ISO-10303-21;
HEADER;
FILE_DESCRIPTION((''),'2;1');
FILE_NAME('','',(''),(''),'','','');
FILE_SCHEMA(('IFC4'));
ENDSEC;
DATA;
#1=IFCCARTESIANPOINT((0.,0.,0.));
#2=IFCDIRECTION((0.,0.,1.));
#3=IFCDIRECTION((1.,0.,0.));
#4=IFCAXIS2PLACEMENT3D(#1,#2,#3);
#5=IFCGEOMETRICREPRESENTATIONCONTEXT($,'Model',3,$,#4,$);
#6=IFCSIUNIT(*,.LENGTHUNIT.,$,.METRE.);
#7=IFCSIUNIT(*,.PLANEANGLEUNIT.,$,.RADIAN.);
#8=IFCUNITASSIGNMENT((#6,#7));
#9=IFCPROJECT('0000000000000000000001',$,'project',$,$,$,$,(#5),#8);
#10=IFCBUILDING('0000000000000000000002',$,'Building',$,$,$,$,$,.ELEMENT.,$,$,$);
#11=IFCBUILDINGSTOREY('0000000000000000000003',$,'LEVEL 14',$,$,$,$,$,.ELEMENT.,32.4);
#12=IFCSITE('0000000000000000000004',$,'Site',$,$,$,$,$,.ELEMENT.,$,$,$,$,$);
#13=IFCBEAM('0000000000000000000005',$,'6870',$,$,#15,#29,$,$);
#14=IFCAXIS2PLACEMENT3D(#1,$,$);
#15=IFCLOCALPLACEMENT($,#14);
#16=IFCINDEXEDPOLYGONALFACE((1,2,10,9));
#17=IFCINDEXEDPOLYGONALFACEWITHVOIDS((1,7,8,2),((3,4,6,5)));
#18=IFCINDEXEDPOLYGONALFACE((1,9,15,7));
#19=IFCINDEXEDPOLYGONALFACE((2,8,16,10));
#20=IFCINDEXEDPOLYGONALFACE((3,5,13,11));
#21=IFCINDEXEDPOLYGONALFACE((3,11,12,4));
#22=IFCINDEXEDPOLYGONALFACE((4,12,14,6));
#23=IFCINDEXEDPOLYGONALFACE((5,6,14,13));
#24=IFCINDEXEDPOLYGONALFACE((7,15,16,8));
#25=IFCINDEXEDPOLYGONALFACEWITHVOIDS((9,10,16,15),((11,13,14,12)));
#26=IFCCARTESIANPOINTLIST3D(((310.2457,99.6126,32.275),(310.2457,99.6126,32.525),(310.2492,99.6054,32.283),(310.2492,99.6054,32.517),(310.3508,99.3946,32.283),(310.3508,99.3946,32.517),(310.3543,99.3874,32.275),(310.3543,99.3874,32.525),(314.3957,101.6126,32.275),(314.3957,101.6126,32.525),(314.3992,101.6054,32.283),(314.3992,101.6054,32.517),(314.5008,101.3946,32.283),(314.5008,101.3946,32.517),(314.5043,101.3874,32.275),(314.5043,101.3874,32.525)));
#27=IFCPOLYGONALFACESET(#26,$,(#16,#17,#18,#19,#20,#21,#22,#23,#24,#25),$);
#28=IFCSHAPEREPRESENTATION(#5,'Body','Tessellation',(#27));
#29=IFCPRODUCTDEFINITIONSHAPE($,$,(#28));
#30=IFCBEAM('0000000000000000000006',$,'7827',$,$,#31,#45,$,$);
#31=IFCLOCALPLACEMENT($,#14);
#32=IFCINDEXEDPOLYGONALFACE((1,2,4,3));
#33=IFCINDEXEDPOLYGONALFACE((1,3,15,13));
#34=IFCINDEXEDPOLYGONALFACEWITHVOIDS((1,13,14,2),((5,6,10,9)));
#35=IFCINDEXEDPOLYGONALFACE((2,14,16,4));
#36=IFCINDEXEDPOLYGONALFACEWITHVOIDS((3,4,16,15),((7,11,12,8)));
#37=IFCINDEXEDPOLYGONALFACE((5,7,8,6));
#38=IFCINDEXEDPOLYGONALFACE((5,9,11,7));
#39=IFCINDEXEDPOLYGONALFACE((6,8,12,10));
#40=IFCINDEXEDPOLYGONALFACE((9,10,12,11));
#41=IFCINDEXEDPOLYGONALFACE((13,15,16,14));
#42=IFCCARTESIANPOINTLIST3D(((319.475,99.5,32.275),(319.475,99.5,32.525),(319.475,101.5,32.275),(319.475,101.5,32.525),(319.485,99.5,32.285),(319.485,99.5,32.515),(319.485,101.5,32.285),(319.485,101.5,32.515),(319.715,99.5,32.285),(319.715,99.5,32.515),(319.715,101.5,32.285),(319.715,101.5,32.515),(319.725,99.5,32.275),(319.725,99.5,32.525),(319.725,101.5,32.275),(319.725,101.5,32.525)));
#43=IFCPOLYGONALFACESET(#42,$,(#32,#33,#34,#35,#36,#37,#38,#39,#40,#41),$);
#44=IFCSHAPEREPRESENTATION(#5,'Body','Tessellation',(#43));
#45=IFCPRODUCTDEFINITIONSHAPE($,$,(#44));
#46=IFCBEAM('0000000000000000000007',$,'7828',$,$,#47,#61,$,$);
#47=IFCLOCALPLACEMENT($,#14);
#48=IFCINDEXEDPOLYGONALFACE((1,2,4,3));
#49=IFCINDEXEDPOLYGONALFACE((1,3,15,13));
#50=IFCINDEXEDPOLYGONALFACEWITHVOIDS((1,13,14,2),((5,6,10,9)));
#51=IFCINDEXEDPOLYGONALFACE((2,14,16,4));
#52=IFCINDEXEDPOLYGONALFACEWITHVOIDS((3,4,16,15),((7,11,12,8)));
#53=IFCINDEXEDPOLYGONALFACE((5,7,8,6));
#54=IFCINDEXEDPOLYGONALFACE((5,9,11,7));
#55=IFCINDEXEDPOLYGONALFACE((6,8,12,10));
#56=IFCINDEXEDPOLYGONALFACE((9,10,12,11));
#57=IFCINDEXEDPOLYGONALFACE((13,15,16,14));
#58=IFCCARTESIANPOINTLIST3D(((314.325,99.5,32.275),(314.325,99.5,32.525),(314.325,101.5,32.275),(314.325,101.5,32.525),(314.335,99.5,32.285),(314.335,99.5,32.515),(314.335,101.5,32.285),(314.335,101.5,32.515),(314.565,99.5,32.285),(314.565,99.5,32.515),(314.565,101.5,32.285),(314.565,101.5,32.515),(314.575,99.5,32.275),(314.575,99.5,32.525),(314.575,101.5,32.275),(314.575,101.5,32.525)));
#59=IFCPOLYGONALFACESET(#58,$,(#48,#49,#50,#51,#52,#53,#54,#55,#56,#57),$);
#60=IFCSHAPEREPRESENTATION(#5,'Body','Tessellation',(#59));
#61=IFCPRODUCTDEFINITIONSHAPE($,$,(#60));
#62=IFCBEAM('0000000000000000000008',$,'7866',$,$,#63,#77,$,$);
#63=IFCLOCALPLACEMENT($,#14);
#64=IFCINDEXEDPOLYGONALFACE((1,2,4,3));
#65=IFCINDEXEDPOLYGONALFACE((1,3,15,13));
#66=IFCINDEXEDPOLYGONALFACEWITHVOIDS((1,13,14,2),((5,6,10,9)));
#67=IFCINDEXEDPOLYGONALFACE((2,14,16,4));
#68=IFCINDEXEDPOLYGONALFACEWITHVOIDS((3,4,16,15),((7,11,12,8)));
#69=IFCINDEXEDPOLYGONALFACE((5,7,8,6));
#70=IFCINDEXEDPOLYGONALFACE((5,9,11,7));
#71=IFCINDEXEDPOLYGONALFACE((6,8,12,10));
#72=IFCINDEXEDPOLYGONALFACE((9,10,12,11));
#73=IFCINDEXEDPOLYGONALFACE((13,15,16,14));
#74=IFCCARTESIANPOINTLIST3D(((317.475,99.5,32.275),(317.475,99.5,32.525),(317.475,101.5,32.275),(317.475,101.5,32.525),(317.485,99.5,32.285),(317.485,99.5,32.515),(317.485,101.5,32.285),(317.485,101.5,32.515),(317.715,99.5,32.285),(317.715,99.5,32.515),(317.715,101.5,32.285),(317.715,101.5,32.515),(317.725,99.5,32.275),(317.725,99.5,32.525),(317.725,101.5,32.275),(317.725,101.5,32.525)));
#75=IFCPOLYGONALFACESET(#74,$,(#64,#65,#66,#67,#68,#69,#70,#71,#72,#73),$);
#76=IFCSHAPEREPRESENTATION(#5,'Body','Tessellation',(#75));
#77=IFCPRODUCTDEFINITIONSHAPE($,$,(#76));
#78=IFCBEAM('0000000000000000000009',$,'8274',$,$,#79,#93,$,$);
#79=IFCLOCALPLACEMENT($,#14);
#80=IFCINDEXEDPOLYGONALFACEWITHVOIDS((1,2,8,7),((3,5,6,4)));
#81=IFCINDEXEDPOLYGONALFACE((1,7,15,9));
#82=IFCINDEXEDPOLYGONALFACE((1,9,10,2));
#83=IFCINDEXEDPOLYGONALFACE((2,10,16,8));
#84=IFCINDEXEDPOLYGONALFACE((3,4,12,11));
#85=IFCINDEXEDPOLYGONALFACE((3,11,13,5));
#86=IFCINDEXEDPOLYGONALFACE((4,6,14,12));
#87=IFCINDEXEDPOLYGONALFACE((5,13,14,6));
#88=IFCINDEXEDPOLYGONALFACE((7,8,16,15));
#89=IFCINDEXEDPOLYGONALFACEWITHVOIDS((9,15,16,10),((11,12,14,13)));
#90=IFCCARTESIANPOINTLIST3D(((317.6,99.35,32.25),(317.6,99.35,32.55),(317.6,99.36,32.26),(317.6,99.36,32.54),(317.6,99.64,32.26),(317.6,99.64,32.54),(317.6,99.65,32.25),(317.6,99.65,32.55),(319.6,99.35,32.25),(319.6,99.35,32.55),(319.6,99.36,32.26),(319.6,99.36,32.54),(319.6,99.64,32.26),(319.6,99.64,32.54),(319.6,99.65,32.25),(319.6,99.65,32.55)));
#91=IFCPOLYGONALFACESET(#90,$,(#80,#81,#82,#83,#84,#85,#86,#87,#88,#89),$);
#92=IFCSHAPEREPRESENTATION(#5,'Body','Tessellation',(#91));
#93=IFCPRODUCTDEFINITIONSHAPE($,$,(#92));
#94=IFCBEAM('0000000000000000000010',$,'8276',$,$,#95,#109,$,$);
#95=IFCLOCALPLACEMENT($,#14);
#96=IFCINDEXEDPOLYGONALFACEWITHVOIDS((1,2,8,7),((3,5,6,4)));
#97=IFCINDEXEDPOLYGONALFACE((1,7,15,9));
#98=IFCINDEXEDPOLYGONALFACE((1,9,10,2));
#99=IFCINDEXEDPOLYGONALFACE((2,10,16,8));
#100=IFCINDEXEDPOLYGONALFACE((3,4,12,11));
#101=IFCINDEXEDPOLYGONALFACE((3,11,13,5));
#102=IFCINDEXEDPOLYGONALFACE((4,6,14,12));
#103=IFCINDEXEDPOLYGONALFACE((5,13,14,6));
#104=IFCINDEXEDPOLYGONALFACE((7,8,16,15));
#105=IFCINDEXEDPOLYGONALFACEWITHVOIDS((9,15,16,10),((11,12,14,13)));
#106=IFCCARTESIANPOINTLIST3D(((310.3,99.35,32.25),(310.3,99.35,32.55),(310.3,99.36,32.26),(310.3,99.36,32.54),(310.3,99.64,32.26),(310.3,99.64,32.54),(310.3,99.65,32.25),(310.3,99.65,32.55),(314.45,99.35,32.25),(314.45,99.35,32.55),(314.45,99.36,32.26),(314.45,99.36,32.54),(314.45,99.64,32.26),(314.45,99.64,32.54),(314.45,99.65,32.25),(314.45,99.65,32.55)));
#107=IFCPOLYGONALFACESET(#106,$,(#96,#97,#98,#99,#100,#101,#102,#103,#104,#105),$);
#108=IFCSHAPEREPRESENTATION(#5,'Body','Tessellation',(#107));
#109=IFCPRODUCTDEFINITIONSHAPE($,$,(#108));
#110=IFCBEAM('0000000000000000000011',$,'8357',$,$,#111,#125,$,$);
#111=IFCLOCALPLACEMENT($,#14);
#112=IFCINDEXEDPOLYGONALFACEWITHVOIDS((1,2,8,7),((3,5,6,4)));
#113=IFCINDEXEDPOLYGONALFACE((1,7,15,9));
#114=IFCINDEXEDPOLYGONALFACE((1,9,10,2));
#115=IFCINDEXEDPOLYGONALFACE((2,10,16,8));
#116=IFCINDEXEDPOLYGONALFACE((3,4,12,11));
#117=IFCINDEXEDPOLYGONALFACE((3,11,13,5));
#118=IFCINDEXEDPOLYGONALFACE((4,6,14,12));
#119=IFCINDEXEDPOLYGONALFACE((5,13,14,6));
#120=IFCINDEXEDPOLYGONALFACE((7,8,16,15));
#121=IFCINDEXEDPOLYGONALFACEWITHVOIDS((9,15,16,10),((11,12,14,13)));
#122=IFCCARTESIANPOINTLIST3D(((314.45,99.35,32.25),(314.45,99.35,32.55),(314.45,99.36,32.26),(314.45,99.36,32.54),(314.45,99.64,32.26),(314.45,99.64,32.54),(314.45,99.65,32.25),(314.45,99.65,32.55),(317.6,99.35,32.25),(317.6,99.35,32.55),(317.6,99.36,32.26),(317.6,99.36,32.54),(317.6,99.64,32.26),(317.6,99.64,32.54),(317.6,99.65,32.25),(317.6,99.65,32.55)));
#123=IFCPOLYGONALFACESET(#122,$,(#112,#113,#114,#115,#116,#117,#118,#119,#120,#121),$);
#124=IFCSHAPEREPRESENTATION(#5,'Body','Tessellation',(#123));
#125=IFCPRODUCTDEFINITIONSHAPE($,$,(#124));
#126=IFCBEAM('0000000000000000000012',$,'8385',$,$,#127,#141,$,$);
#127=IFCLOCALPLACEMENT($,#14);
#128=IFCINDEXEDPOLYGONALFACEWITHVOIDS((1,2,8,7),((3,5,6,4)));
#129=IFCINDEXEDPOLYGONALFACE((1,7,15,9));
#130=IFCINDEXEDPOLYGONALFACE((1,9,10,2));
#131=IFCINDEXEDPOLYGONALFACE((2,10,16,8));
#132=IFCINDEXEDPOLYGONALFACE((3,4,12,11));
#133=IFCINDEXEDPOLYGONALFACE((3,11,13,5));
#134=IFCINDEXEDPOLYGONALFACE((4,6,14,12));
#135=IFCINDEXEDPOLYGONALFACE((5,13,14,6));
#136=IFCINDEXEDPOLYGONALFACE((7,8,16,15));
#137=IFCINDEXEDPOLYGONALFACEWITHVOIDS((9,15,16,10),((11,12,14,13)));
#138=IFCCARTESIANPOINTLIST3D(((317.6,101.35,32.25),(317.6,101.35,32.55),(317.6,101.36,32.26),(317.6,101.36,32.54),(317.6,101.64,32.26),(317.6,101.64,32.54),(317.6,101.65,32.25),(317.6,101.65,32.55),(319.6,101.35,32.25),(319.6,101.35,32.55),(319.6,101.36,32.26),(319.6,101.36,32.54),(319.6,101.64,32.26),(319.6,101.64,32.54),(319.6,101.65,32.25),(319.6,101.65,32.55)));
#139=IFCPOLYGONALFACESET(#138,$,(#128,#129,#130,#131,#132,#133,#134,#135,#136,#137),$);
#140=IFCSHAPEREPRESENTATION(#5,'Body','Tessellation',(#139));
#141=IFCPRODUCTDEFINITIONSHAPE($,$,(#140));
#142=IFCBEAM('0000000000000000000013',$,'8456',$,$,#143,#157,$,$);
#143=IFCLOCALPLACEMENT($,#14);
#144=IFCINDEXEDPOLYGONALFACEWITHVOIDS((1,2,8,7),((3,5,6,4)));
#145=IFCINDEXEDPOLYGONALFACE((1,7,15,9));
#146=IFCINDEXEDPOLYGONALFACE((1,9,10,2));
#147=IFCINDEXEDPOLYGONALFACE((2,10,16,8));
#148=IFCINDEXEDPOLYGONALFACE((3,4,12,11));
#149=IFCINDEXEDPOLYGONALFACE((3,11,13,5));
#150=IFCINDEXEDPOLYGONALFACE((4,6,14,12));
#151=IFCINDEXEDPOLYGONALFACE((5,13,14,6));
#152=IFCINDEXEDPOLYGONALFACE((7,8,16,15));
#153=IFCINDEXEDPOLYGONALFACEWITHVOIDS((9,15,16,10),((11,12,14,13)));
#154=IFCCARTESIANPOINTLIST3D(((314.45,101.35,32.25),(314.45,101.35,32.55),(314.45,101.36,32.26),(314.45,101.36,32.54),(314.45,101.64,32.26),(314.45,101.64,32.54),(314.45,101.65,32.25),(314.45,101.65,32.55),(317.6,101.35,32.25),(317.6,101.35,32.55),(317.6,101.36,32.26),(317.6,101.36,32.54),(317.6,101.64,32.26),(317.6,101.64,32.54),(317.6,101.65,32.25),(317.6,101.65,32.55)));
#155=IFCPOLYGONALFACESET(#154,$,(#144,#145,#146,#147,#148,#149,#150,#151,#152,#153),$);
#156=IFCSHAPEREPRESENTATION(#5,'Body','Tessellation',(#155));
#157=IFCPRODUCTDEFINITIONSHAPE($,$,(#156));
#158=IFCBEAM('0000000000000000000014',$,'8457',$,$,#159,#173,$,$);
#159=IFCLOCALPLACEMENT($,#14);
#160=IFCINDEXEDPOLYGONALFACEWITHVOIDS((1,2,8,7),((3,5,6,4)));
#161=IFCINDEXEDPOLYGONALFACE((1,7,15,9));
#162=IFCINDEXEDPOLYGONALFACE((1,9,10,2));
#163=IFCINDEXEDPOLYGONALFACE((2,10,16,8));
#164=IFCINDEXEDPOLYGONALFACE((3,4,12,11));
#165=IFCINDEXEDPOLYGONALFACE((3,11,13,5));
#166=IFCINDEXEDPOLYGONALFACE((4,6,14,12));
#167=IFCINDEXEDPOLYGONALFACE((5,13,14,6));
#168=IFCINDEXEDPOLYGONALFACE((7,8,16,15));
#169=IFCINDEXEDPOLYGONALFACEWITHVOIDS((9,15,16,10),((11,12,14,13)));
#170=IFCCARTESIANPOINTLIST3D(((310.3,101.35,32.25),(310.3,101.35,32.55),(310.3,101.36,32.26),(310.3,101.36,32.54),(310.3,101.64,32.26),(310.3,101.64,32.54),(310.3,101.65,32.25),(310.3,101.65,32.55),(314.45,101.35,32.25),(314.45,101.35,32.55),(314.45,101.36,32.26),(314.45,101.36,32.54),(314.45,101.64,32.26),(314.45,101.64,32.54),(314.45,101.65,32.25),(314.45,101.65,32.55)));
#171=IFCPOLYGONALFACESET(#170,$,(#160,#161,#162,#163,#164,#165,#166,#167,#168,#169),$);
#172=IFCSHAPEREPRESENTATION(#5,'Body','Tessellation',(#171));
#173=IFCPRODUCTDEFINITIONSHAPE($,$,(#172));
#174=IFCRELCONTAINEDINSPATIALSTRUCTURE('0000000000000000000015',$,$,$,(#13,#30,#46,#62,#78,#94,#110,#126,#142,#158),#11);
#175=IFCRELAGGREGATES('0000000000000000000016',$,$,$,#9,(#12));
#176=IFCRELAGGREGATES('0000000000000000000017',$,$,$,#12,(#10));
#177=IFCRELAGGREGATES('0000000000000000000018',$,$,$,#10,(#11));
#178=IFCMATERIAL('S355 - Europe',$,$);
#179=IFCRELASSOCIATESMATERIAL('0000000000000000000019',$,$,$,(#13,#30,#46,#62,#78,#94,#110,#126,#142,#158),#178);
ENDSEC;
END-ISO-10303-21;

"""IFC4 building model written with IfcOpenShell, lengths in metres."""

from ifc_helpers import new_model, si_unit, frame, origin_with_axes, origin_2d_with_axis, place, context, project, spatial, hollow_rectangle, extrude, material, material_profile, profile_set, profile_usage, element, save


model = new_model("IFC4")

# Units and contexts
model_context = context("Model", 3, world=origin_with_axes())
ifc_project = project(units=[si_unit("LENGTHUNIT", "METRE"), si_unit("PLANEANGLEUNIT", "RADIAN")], contexts=[model_context])

# Site, building, storey
site = spatial("IfcSite", under=ifc_project, Name="Site", CompositionType="ELEMENT")
building = spatial("IfcBuilding", under=site, Name="Building", CompositionType="ELEMENT")
storey = spatial("IfcBuildingStorey", under=building, Name="LEVEL 14", CompositionType="ELEMENT", Elevation=32.4)

# Shared definitions
ifc_material = material(Name="S355 - Europe")

# Beams
ifc_material_profile_1 = material_profile(ifc_material, hollow_rectangle(XDim=0.25, YDim=0.25, WallThickness=0.008, at=origin_2d_with_axis()))
ifc_profile_set_1 = profile_set([ifc_material_profile_1])
ifc_profile_usage_1 = profile_usage(ifc_profile_set_1, cardinal=10)
beam_1_placement = place(None, frame((314.45, 101.5, 32.4), z_axis=(-0.900844, -0.434142, 0.0), x_axis=(0.434142, -0.900844, 0.0)))
element("IfcBeam", 1, at=beam_1_placement, inside=storey, material=ifc_profile_usage_1, Name="6870", context=model_context, shape_type="SweptSolid", body=[
    extrude(hollow_rectangle(XDim=0.25, YDim=0.25, WallThickness=0.008, at=origin_2d_with_axis()), origin_with_axes(), (0.0, 0.0, 1.0), 4.6068),
])
ifc_material_profile_2 = material_profile(ifc_material, hollow_rectangle(XDim=0.25, YDim=0.25, WallThickness=0.01, at=origin_2d_with_axis()))
ifc_profile_set_2 = profile_set([ifc_material_profile_2])
ifc_profile_usage_2 = profile_usage(ifc_profile_set_2, cardinal=10)
beam_2_placement = place(None, frame((319.6, 101.5, 32.4), z_axis=(0.0, -1.0, 0.0), x_axis=(1.0, 0.0, 0.0)))
element("IfcBeam", 2, at=beam_2_placement, inside=storey, material=ifc_profile_usage_2, Name="7827", context=model_context, shape_type="SweptSolid", body=[
    extrude(hollow_rectangle(XDim=0.25, YDim=0.25, WallThickness=0.01, at=origin_2d_with_axis()), origin_with_axes(), (0.0, 0.0, 1.0), 2.0),
])
ifc_material_profile_3 = material_profile(ifc_material, hollow_rectangle(XDim=0.25, YDim=0.25, WallThickness=0.01, at=origin_2d_with_axis()))
ifc_profile_set_3 = profile_set([ifc_material_profile_3])
ifc_profile_usage_3 = profile_usage(ifc_profile_set_3, cardinal=10)
beam_3_placement = place(None, frame((314.45, 101.5, 32.4), z_axis=(0.0, -1.0, 0.0), x_axis=(1.0, 0.0, 0.0)))
element("IfcBeam", 3, at=beam_3_placement, inside=storey, material=ifc_profile_usage_3, Name="7828", context=model_context, shape_type="SweptSolid", body=[
    extrude(hollow_rectangle(XDim=0.25, YDim=0.25, WallThickness=0.01, at=origin_2d_with_axis()), origin_with_axes(), (0.0, 0.0, 1.0), 2.0),
])
ifc_material_profile_4 = material_profile(ifc_material, hollow_rectangle(XDim=0.25, YDim=0.25, WallThickness=0.01, at=origin_2d_with_axis()))
ifc_profile_set_4 = profile_set([ifc_material_profile_4])
ifc_profile_usage_4 = profile_usage(ifc_profile_set_4, cardinal=10)
beam_4_placement = place(None, frame((317.6, 101.5, 32.4), z_axis=(0.0, -1.0, 0.0), x_axis=(1.0, 0.0, 0.0)))
element("IfcBeam", 4, at=beam_4_placement, inside=storey, material=ifc_profile_usage_4, Name="7866", context=model_context, shape_type="SweptSolid", body=[
    extrude(hollow_rectangle(XDim=0.25, YDim=0.25, WallThickness=0.01, at=origin_2d_with_axis()), origin_with_axes(), (0.0, 0.0, 1.0), 2.0),
])
ifc_material_profile_5 = material_profile(ifc_material, hollow_rectangle(XDim=0.3, YDim=0.3, WallThickness=0.01, at=origin_2d_with_axis()))
ifc_profile_set_5 = profile_set([ifc_material_profile_5])
ifc_profile_usage_5 = profile_usage(ifc_profile_set_5, cardinal=10)
beam_5_placement = place(None, frame((319.6, 99.5, 32.4), z_axis=(-1.0, 0.0, 0.0), x_axis=(0.0, -1.0, 0.0)))
element("IfcBeam", 5, at=beam_5_placement, inside=storey, material=ifc_profile_usage_5, Name="8274", context=model_context, shape_type="SweptSolid", body=[
    extrude(hollow_rectangle(XDim=0.3, YDim=0.3, WallThickness=0.01, at=origin_2d_with_axis()), origin_with_axes(), (0.0, 0.0, 1.0), 2.0),
])
ifc_material_profile_6 = material_profile(ifc_material, hollow_rectangle(XDim=0.3, YDim=0.3, WallThickness=0.01, at=origin_2d_with_axis()))
ifc_profile_set_6 = profile_set([ifc_material_profile_6])
ifc_profile_usage_6 = profile_usage(ifc_profile_set_6, cardinal=10)
beam_6_placement = place(None, frame((314.45, 99.5, 32.4), z_axis=(-1.0, 0.0, 0.0), x_axis=(0.0, -1.0, 0.0)))
element("IfcBeam", 6, at=beam_6_placement, inside=storey, material=ifc_profile_usage_6, Name="8276", context=model_context, shape_type="SweptSolid", body=[
    extrude(hollow_rectangle(XDim=0.3, YDim=0.3, WallThickness=0.01, at=origin_2d_with_axis()), origin_with_axes(), (0.0, 0.0, 1.0), 4.15),
])
ifc_material_profile_7 = material_profile(ifc_material, hollow_rectangle(XDim=0.3, YDim=0.3, WallThickness=0.01, at=origin_2d_with_axis()))
ifc_profile_set_7 = profile_set([ifc_material_profile_7])
ifc_profile_usage_7 = profile_usage(ifc_profile_set_7, cardinal=10)
beam_7_placement = place(None, frame((317.6, 99.5, 32.4), z_axis=(-1.0, 0.0, 0.0), x_axis=(0.0, -1.0, 0.0)))
element("IfcBeam", 7, at=beam_7_placement, inside=storey, material=ifc_profile_usage_7, Name="8357", context=model_context, shape_type="SweptSolid", body=[
    extrude(hollow_rectangle(XDim=0.3, YDim=0.3, WallThickness=0.01, at=origin_2d_with_axis()), origin_with_axes(), (0.0, 0.0, 1.0), 3.15),
])
ifc_material_profile_8 = material_profile(ifc_material, hollow_rectangle(XDim=0.3, YDim=0.3, WallThickness=0.01, at=origin_2d_with_axis()))
ifc_profile_set_8 = profile_set([ifc_material_profile_8])
ifc_profile_usage_8 = profile_usage(ifc_profile_set_8, cardinal=10)
beam_8_placement = place(None, frame((319.6, 101.5, 32.4), z_axis=(-1.0, 0.0, 0.0), x_axis=(0.0, -1.0, 0.0)))
element("IfcBeam", 8, at=beam_8_placement, inside=storey, material=ifc_profile_usage_8, Name="8385", context=model_context, shape_type="SweptSolid", body=[
    extrude(hollow_rectangle(XDim=0.3, YDim=0.3, WallThickness=0.01, at=origin_2d_with_axis()), origin_with_axes(), (0.0, 0.0, 1.0), 2.0),
])
ifc_material_profile_9 = material_profile(ifc_material, hollow_rectangle(XDim=0.3, YDim=0.3, WallThickness=0.01, at=origin_2d_with_axis()))
ifc_profile_set_9 = profile_set([ifc_material_profile_9])
ifc_profile_usage_9 = profile_usage(ifc_profile_set_9, cardinal=10)
beam_9_placement = place(None, frame((317.6, 101.5, 32.4), z_axis=(-1.0, 0.0, 0.0), x_axis=(0.0, -1.0, 0.0)))
element("IfcBeam", 9, at=beam_9_placement, inside=storey, material=ifc_profile_usage_9, Name="8456", context=model_context, shape_type="SweptSolid", body=[
    extrude(hollow_rectangle(XDim=0.3, YDim=0.3, WallThickness=0.01, at=origin_2d_with_axis()), origin_with_axes(), (0.0, 0.0, 1.0), 3.15),
])
ifc_material_profile_10 = material_profile(ifc_material, hollow_rectangle(XDim=0.3, YDim=0.3, WallThickness=0.01, at=origin_2d_with_axis()))
ifc_profile_set_10 = profile_set([ifc_material_profile_10])
ifc_profile_usage_10 = profile_usage(ifc_profile_set_10, cardinal=10)
beam_10_placement = place(None, frame((314.45, 101.5, 32.4), z_axis=(-1.0, 0.0, 0.0), x_axis=(0.0, -1.0, 0.0)))
element("IfcBeam", 10, at=beam_10_placement, inside=storey, material=ifc_profile_usage_10, Name="8457", context=model_context, shape_type="SweptSolid", body=[
    extrude(hollow_rectangle(XDim=0.3, YDim=0.3, WallThickness=0.01, at=origin_2d_with_axis()), origin_with_axes(), (0.0, 0.0, 1.0), 4.15),
])

save(model, "model.ifc")
